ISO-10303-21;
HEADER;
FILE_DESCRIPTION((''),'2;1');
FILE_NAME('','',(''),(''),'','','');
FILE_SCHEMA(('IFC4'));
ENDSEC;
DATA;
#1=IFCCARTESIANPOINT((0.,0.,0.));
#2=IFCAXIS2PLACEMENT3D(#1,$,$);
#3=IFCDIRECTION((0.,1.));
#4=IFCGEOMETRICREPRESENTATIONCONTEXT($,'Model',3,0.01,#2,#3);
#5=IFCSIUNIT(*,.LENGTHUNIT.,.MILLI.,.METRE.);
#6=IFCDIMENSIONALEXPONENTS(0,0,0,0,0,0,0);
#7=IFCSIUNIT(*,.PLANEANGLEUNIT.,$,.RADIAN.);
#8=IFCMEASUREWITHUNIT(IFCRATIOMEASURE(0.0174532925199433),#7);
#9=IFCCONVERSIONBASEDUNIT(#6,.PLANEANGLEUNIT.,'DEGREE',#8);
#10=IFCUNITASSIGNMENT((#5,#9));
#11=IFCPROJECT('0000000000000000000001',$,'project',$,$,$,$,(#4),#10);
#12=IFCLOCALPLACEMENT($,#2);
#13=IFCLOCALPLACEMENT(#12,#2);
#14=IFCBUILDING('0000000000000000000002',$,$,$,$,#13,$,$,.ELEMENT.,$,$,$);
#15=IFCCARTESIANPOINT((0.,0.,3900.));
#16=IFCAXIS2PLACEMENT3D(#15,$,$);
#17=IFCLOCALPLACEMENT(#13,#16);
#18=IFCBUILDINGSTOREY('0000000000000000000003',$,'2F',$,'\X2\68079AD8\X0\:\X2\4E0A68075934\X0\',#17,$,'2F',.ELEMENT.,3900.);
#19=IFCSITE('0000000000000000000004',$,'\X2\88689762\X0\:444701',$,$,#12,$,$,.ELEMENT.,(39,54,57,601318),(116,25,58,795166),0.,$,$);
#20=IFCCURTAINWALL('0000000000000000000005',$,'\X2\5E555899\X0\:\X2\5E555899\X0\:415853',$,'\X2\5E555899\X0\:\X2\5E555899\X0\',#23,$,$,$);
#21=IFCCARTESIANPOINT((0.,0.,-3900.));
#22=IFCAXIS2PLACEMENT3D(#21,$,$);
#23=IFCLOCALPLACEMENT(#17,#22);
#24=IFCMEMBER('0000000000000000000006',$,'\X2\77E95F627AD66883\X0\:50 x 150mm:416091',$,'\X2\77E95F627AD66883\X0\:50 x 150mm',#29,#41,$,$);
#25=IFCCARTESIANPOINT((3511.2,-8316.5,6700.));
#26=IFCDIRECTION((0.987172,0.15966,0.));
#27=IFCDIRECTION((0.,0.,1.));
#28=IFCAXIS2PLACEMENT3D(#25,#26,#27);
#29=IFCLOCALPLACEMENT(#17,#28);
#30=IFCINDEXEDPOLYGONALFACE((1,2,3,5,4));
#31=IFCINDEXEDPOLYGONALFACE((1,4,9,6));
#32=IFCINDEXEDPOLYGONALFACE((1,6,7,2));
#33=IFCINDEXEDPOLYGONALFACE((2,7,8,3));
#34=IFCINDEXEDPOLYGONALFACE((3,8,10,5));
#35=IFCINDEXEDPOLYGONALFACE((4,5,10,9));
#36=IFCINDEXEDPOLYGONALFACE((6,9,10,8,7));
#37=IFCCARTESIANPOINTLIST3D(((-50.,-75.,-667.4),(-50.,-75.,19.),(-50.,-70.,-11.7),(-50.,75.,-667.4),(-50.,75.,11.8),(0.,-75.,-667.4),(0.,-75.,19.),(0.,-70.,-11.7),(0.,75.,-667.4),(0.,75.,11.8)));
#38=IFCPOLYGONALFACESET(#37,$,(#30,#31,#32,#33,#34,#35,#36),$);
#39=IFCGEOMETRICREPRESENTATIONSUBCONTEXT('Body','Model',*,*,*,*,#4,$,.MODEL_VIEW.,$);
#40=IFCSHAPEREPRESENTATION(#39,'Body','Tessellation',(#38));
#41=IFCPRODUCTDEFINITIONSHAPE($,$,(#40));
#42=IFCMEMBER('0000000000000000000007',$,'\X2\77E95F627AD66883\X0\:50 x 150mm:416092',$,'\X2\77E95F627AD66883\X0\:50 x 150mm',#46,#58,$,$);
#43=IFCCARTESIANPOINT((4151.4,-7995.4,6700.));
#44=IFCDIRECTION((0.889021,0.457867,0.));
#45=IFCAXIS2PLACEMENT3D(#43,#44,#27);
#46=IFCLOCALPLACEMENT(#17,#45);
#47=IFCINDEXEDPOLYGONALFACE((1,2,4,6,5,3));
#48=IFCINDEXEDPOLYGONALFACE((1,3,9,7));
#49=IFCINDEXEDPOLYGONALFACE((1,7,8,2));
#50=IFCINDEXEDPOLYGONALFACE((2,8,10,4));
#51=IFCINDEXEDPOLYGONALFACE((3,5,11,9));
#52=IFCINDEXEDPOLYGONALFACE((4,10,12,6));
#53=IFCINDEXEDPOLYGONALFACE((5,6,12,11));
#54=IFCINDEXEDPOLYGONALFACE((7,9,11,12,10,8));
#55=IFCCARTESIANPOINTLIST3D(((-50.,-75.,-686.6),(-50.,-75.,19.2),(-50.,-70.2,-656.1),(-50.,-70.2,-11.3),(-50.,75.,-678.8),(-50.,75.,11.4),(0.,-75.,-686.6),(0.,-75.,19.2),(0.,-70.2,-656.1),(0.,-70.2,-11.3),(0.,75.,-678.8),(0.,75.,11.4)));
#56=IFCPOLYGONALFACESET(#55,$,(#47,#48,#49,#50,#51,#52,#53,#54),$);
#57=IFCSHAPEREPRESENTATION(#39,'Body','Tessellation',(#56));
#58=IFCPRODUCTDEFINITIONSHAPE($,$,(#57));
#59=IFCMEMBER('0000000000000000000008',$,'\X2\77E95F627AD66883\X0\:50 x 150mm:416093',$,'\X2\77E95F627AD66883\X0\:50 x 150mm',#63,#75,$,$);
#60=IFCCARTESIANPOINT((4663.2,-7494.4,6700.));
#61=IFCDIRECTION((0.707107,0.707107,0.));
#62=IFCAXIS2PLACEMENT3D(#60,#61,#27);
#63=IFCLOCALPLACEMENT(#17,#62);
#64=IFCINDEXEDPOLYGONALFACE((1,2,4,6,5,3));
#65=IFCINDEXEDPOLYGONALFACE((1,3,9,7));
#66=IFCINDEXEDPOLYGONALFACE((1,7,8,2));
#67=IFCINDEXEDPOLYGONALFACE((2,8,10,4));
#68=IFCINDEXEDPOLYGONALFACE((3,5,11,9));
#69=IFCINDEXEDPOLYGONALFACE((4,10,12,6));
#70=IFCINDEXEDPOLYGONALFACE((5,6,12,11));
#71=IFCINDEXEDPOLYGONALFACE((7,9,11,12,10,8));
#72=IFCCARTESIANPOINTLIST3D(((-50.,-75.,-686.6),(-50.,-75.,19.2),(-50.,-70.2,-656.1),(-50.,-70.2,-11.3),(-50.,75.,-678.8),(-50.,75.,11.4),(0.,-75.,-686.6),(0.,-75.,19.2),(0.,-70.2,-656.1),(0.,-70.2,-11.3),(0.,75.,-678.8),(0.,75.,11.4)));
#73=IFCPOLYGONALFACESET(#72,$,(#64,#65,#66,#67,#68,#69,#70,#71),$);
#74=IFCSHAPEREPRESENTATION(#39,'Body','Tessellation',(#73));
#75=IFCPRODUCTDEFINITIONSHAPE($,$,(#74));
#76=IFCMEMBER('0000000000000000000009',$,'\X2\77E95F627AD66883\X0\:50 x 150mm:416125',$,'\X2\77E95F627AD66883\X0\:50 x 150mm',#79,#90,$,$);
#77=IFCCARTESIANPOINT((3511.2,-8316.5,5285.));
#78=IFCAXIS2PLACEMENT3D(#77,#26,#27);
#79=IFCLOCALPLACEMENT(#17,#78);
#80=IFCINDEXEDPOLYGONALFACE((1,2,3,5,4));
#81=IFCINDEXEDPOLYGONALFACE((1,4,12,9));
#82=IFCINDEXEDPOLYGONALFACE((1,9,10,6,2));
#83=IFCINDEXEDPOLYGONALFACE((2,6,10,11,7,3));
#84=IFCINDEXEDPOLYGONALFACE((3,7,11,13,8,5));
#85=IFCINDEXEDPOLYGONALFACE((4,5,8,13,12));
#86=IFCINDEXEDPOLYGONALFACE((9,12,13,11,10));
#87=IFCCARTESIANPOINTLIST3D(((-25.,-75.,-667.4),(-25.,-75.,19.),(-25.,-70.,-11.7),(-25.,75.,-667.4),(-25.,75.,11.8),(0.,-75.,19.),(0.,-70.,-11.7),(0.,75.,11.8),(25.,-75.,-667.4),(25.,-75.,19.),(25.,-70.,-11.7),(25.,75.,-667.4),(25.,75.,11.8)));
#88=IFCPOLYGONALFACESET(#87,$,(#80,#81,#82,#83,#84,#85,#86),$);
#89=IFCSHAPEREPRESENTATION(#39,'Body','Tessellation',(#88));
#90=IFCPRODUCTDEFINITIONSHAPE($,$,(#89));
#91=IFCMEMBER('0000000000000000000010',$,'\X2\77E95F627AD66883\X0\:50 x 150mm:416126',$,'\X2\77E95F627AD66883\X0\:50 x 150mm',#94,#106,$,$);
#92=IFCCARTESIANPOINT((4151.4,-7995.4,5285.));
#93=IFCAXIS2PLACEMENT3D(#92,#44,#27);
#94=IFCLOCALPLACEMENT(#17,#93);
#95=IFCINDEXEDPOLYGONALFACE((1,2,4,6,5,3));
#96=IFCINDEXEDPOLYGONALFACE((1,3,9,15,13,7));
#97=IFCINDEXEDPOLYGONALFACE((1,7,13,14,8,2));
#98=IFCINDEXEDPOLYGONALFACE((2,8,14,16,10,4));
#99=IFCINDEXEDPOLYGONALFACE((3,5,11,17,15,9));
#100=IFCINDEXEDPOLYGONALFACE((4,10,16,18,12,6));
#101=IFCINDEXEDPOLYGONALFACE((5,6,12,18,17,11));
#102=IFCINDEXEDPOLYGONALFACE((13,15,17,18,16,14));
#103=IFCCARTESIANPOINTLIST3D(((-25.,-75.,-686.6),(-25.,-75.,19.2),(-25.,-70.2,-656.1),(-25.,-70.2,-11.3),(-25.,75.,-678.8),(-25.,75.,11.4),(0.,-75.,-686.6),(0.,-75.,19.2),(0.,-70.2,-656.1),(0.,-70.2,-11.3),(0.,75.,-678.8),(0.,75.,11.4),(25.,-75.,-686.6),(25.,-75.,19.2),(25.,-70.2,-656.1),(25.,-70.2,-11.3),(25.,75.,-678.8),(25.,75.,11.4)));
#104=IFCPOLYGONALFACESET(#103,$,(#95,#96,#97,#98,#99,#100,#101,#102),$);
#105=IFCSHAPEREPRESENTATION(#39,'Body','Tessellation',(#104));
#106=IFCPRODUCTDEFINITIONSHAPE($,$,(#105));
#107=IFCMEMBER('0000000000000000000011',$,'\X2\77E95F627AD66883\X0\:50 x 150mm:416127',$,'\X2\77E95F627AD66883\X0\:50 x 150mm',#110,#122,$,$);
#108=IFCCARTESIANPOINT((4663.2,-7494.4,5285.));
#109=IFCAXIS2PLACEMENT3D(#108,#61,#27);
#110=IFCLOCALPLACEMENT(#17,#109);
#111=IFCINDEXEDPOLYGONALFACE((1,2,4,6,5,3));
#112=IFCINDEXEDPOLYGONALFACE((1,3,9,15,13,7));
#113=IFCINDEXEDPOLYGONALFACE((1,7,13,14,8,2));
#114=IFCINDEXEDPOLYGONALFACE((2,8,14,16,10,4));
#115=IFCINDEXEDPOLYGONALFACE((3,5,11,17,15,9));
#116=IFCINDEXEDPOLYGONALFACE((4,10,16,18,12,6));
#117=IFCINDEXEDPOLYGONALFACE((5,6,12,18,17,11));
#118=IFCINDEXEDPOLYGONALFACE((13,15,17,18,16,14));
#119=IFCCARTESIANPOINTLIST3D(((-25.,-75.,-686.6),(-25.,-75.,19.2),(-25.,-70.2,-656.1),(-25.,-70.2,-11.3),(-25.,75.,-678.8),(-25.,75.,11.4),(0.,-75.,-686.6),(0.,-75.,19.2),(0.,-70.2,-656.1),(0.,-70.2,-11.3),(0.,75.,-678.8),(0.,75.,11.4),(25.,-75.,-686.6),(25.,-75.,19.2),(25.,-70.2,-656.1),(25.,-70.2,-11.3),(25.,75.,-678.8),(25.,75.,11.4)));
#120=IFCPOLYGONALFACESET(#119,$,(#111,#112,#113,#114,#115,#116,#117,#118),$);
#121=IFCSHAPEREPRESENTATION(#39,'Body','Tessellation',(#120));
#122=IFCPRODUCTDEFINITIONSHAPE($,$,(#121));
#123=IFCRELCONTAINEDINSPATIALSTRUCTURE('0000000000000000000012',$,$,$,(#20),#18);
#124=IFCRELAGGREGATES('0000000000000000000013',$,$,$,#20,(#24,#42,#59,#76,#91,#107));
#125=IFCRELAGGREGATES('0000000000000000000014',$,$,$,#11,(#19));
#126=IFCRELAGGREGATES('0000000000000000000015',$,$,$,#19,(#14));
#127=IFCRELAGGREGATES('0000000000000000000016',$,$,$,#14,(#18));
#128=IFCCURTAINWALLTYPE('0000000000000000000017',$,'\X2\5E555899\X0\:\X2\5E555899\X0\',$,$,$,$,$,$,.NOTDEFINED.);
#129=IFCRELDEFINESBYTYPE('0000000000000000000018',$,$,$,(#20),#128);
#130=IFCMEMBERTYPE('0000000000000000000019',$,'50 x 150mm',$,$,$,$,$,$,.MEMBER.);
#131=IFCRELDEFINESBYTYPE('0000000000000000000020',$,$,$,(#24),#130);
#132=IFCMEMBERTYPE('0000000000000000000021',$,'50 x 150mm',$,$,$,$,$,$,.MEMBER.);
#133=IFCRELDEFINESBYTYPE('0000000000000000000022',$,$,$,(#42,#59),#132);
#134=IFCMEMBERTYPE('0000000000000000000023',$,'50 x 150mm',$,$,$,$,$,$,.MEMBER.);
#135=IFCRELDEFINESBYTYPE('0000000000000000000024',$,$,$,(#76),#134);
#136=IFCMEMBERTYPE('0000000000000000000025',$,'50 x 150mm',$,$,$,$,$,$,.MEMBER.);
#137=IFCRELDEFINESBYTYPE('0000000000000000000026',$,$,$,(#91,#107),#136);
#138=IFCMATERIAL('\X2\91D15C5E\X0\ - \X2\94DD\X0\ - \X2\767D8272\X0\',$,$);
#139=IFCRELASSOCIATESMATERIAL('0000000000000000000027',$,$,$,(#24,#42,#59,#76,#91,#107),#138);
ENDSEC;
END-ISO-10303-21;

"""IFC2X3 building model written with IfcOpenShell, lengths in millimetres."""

from ifc_helpers import new_model, entity, si_unit, converted_unit, direction, frame, origin, origin_2d_with_axis, place, context, subcontext, project, spatial, polyline, rectangle, extrude, clip, bounded_halfspace, source, transform, mapped, material, type_object, type_shapes, element, aggregate, save


model = new_model("IFC2X3")

# Units and contexts
model_context = context("Model", 3, precision=0.01, world=origin(), true_north=direction((0.0, 1.0)))
body_context = subcontext(model_context, "Body", "Model", "MODEL_VIEW")
ifc_project = project(units=[si_unit("LENGTHUNIT", "METRE", prefix="MILLI"), converted_unit("PLANEANGLEUNIT", "DEGREE", entity("IfcRatioMeasure", 0.0174532925199433), si_unit("PLANEANGLEUNIT", "RADIAN"), dimensions=[0, 0, 0, 0, 0, 0, 0])], contexts=[model_context])

# Site, building, storey
site_placement = place(None, origin())
site = spatial("IfcSite", under=ifc_project, at=site_placement, Name="表面:444701", CompositionType="ELEMENT", RefLatitude=(39, 54, 57, 601318), RefLongitude=(116, 25, 58, 795166), RefElevation=0.0)
building_placement = place(site_placement, origin())
building = spatial("IfcBuilding", under=site, at=building_placement, CompositionType="ELEMENT")
storey_placement = place(building_placement, frame((0.0, 0.0, 3900.0)))
storey = spatial("IfcBuildingStorey", under=building, at=storey_placement, Name="2F", ObjectType="标高:上标头", LongName="2F", CompositionType="ELEMENT", Elevation=3900.0)

# Curtain wall
curtain_wall_type = type_object("IfcCurtainWallType", Name="幕墙:幕墙", PredefinedType="NOTDEFINED")
curtain_wall_1_placement = place(storey_placement, frame((0.0, 0.0, -3900.0)))
curtain_wall_1 = element("IfcCurtainWall", 1, at=curtain_wall_1_placement, inside=storey, type_object=curtain_wall_type, Name="幕墙:幕墙:415853", ObjectType="幕墙:幕墙")
ifc_material_1 = material(Name="金属 - 铝 - 白色")

# Members
member_type_1 = type_object("IfcMemberType", Name="50 x 150mm", PredefinedType="MEMBER")
shared_shape_1 = source(origin(), body_context, "Body", "Clipping", [
    clip(clip(extrude(rectangle(XDim=50.0, YDim=150.0, at=origin_2d_with_axis()), frame((-25.0, 0.0, -667.4)), (0.0, 0.0, 1.0), 686.4), bounded_halfspace(frame((-1415.0, -70.0, -11.7), z_axis=(0.0, 0.987172, 0.15966), x_axis=(1.0, 0.0, 0.0)), False, frame((-25.0, 0.0, -667.4)), polyline([(-25.0, -70.0), (-25.0, -75.0), (25.0, -75.0), (25.0, -70.0), (-25.0, -70.0)]))), bounded_halfspace(frame((-1415.0, 78.0, 12.3), z_axis=(0.0, -0.15966, 0.987172), x_axis=(1.0, 0.0, 0.0)), False, frame((-25.0, 0.0, -667.4)), polyline([(25.0, 75.0), (-25.0, 75.0), (-25.0, -70.0), (25.0, -70.0), (25.0, 75.0)]))),
])
type_shapes(member_type_1, [shared_shape_1])
member_1_placement = place(storey_placement, frame((3511.2, -8316.5, 6700.0), z_axis=(0.987172, 0.15966, 0.0), x_axis=(0.0, 0.0, 1.0)))
member_1 = element("IfcMember", 2, at=member_1_placement, type_object=member_type_1, material=ifc_material_1, Name="矩形竖梃:50 x 150mm:416091", ObjectType="矩形竖梃:50 x 150mm", context=body_context, shape_type="MappedRepresentation", body=[
    mapped(shared_shape_1, transform((0.0, 0.0, 0.0), scale=1.0)),
])
member_type_2 = type_object("IfcMemberType", Name="50 x 150mm", PredefinedType="MEMBER")
shared_shape_2 = source(origin(), body_context, "Body", "Clipping", [
    clip(clip(clip(clip(extrude(rectangle(XDim=50.0, YDim=150.0, at=origin_2d_with_axis()), frame((-25.0, 0.0, -686.6)), (0.0, 0.0, 1.0), 705.8), bounded_halfspace(frame((-1415.0, -70.2, -656.1), z_axis=(0.0, -0.154283, -0.988027), x_axis=(1.0, 0.0, 0.0)), False, frame((-25.0, 0.0, -686.6)), polyline([(25.0, 75.0), (25.0, -70.2), (-25.0, -70.2), (-25.0, 75.0), (25.0, 75.0)]))), bounded_halfspace(frame((-1415.0, -78.0, -705.5), z_axis=(0.0, 0.988027, -0.154283), x_axis=(1.0, 0.0, 0.0)), False, frame((-25.0, 0.0, -686.6)), polyline([(25.0, -70.2), (25.0, -75.0), (-25.0, -75.0), (-25.0, -70.2), (25.0, -70.2)]))), bounded_halfspace(frame((-1415.0, -70.2, -11.3), z_axis=(0.0, 0.988027, 0.154283), x_axis=(1.0, 0.0, 0.0)), False, frame((-25.0, 0.0, -686.6)), polyline([(-25.0, -70.2), (-25.0, -75.0), (25.0, -75.0), (25.0, -70.2), (-25.0, -70.2)]))), bounded_halfspace(frame((-1415.0, 78.0, 11.9), z_axis=(0.0, -0.154283, 0.988027), x_axis=(1.0, 0.0, 0.0)), False, frame((-25.0, 0.0, -686.6)), polyline([(25.0, 75.0), (-25.0, 75.0), (-25.0, -70.2), (25.0, -70.2), (25.0, 75.0)]))),
])
type_shapes(member_type_2, [shared_shape_2])
member_2_placement = place(storey_placement, frame((4151.4, -7995.4, 6700.0), z_axis=(0.889021, 0.457867, 0.0), x_axis=(0.0, 0.0, 1.0)))
member_2 = element("IfcMember", 3, at=member_2_placement, type_object=member_type_2, material=ifc_material_1, Name="矩形竖梃:50 x 150mm:416092", ObjectType="矩形竖梃:50 x 150mm", context=body_context, shape_type="MappedRepresentation", body=[
    mapped(shared_shape_2, transform((0.0, 0.0, 0.0), scale=1.0)),
])
member_3_placement = place(storey_placement, frame((4663.2, -7494.4, 6700.0), z_axis=(0.707107, 0.707107, 0.0), x_axis=(0.0, 0.0, 1.0)))
member_3 = element("IfcMember", 4, at=member_3_placement, type_object=member_type_2, material=ifc_material_1, Name="矩形竖梃:50 x 150mm:416093", ObjectType="矩形竖梃:50 x 150mm", context=body_context, shape_type="MappedRepresentation", body=[
    mapped(shared_shape_2, transform((0.0, 0.0, 0.0), scale=1.0)),
])
member_type_3 = type_object("IfcMemberType", Name="50 x 150mm", PredefinedType="MEMBER")
shared_shape_3 = source(origin(), body_context, "Body", "Clipping", [
    clip(clip(clip(clip(extrude(rectangle(XDim=150.0, YDim=50.0, at=origin_2d_with_axis()), frame((0.0, 0.0, -667.4), z_axis=(0.0, 0.0, 1.0), x_axis=(0.0, -1.0, 0.0)), (0.0, 0.0, 1.0), 686.4), bounded_halfspace(frame((-1390.0, -70.0, -11.7), z_axis=(0.0, 0.987172, 0.15966), x_axis=(1.0, 0.0, 0.0)), False, frame((0.0, 0.0, -667.4), z_axis=(0.0, 0.0, 1.0), x_axis=(0.0, -1.0, 0.0)), polyline([(70.0, -25.0), (75.0, -25.0), (75.0, 0.0), (70.0, 0.0), (70.0, -25.0)]))), bounded_halfspace(frame((0.0, -70.0, -11.7), z_axis=(0.0, 0.987172, 0.15966), x_axis=(1.0, 0.0, 0.0)), False, frame((0.0, 0.0, -667.4), z_axis=(0.0, 0.0, 1.0), x_axis=(0.0, -1.0, 0.0)), polyline([(75.0, 0.0), (75.0, 25.0), (70.0, 25.0), (70.0, 0.0), (75.0, 0.0)]))), bounded_halfspace(frame((-1390.0, 78.0, 12.3), z_axis=(0.0, -0.15966, 0.987172), x_axis=(1.0, 0.0, 0.0)), False, frame((0.0, 0.0, -667.4), z_axis=(0.0, 0.0, 1.0), x_axis=(0.0, -1.0, 0.0)), polyline([(-75.0, 0.0), (-75.0, -25.0), (70.0, -25.0), (70.0, 0.0), (-75.0, 0.0)]))), bounded_halfspace(frame((0.0, 78.0, 12.3), z_axis=(0.0, -0.15966, 0.987172), x_axis=(1.0, 0.0, 0.0)), False, frame((0.0, 0.0, -667.4), z_axis=(0.0, 0.0, 1.0), x_axis=(0.0, -1.0, 0.0)), polyline([(-75.0, 25.0), (-75.0, 0.0), (70.0, 0.0), (70.0, 25.0), (-75.0, 25.0)]))),
])
type_shapes(member_type_3, [shared_shape_3])
member_4_placement = place(storey_placement, frame((3511.2, -8316.5, 5285.0), z_axis=(0.987172, 0.15966, 0.0), x_axis=(0.0, 0.0, 1.0)))
member_4 = element("IfcMember", 5, at=member_4_placement, type_object=member_type_3, material=ifc_material_1, Name="矩形竖梃:50 x 150mm:416125", ObjectType="矩形竖梃:50 x 150mm", context=body_context, shape_type="MappedRepresentation", body=[
    mapped(shared_shape_3, transform((0.0, 0.0, 0.0), scale=1.0)),
])
member_type_4 = type_object("IfcMemberType", Name="50 x 150mm", PredefinedType="MEMBER")
shared_shape_4 = source(origin(), body_context, "Body", "Clipping", [
    clip(clip(clip(clip(clip(clip(clip(clip(extrude(rectangle(XDim=150.0, YDim=50.0, at=origin_2d_with_axis()), frame((0.0, 0.0, -686.6), z_axis=(0.0, 0.0, 1.0), x_axis=(0.0, -1.0, 0.0)), (0.0, 0.0, 1.0), 705.8), bounded_halfspace(frame((-1390.0, -70.2, -656.1), z_axis=(0.0, -0.154283, -0.988027), x_axis=(1.0, 0.0, 0.0)), False, frame((0.0, 0.0, -686.6), z_axis=(0.0, 0.0, 1.0), x_axis=(0.0, -1.0, 0.0)), polyline([(70.2, -25.0), (-75.0, -25.0), (-75.0, 0.0), (70.2, 0.0), (70.2, -25.0)]))), bounded_halfspace(frame((0.0, -70.2, -656.1), z_axis=(0.0, -0.154283, -0.988027), x_axis=(1.0, 0.0, 0.0)), False, frame((0.0, 0.0, -686.6), z_axis=(0.0, 0.0, 1.0), x_axis=(0.0, -1.0, 0.0)), polyline([(-75.0, 25.0), (70.2, 25.0), (70.2, 0.0), (-75.0, 0.0), (-75.0, 25.0)]))), bounded_halfspace(frame((-1390.0, -78.0, -705.5), z_axis=(0.0, 0.988027, -0.154283), x_axis=(1.0, 0.0, 0.0)), False, frame((0.0, 0.0, -686.6), z_axis=(0.0, 0.0, 1.0), x_axis=(0.0, -1.0, 0.0)), polyline([(75.0, 0.0), (75.0, -25.0), (70.2, -25.0), (70.2, 0.0), (75.0, 0.0)]))), bounded_halfspace(frame((0.0, -78.0, -705.5), z_axis=(0.0, 0.988027, -0.154283), x_axis=(1.0, 0.0, 0.0)), False, frame((0.0, 0.0, -686.6), z_axis=(0.0, 0.0, 1.0), x_axis=(0.0, -1.0, 0.0)), polyline([(70.2, 25.0), (75.0, 25.0), (75.0, 0.0), (70.2, 0.0), (70.2, 25.0)]))), bounded_halfspace(frame((-1390.0, -70.2, -11.3), z_axis=(0.0, 0.988027, 0.154283), x_axis=(1.0, 0.0, 0.0)), False, frame((0.0, 0.0, -686.6), z_axis=(0.0, 0.0, 1.0), x_axis=(0.0, -1.0, 0.0)), polyline([(70.2, -25.0), (75.0, -25.0), (75.0, 0.0), (70.2, 0.0), (70.2, -25.0)]))), bounded_halfspace(frame((0.0, -70.2, -11.3), z_axis=(0.0, 0.988027, 0.154283), x_axis=(1.0, 0.0, 0.0)), False, frame((0.0, 0.0, -686.6), z_axis=(0.0, 0.0, 1.0), x_axis=(0.0, -1.0, 0.0)), polyline([(75.0, 0.0), (75.0, 25.0), (70.2, 25.0), (70.2, 0.0), (75.0, 0.0)]))), bounded_halfspace(frame((-1390.0, 78.0, 11.9), z_axis=(0.0, -0.154283, 0.988027), x_axis=(1.0, 0.0, 0.0)), False, frame((0.0, 0.0, -686.6), z_axis=(0.0, 0.0, 1.0), x_axis=(0.0, -1.0, 0.0)), polyline([(-75.0, 0.0), (-75.0, -25.0), (70.2, -25.0), (70.2, 0.0), (-75.0, 0.0)]))), bounded_halfspace(frame((0.0, 78.0, 11.9), z_axis=(0.0, -0.154283, 0.988027), x_axis=(1.0, 0.0, 0.0)), False, frame((0.0, 0.0, -686.6), z_axis=(0.0, 0.0, 1.0), x_axis=(0.0, -1.0, 0.0)), polyline([(-75.0, 25.0), (-75.0, 0.0), (70.2, 0.0), (70.2, 25.0), (-75.0, 25.0)]))),
])
type_shapes(member_type_4, [shared_shape_4])
member_5_placement = place(storey_placement, frame((4151.4, -7995.4, 5285.0), z_axis=(0.889021, 0.457867, 0.0), x_axis=(0.0, 0.0, 1.0)))
member_5 = element("IfcMember", 6, at=member_5_placement, type_object=member_type_4, material=ifc_material_1, Name="矩形竖梃:50 x 150mm:416126", ObjectType="矩形竖梃:50 x 150mm", context=body_context, shape_type="MappedRepresentation", body=[
    mapped(shared_shape_4, transform((0.0, 0.0, 0.0), scale=1.0)),
])
member_6_placement = place(storey_placement, frame((4663.2, -7494.4, 5285.0), z_axis=(0.707107, 0.707107, 0.0), x_axis=(0.0, 0.0, 1.0)))
member_6 = element("IfcMember", 7, at=member_6_placement, type_object=member_type_4, material=ifc_material_1, Name="矩形竖梃:50 x 150mm:416127", ObjectType="矩形竖梃:50 x 150mm", context=body_context, shape_type="MappedRepresentation", body=[
    mapped(shared_shape_4, transform((0.0, 0.0, 0.0), scale=1.0)),
])

aggregate(curtain_wall_1, [member_1, member_2, member_3, member_4, member_5, member_6])

save(model, "model.ifc")
